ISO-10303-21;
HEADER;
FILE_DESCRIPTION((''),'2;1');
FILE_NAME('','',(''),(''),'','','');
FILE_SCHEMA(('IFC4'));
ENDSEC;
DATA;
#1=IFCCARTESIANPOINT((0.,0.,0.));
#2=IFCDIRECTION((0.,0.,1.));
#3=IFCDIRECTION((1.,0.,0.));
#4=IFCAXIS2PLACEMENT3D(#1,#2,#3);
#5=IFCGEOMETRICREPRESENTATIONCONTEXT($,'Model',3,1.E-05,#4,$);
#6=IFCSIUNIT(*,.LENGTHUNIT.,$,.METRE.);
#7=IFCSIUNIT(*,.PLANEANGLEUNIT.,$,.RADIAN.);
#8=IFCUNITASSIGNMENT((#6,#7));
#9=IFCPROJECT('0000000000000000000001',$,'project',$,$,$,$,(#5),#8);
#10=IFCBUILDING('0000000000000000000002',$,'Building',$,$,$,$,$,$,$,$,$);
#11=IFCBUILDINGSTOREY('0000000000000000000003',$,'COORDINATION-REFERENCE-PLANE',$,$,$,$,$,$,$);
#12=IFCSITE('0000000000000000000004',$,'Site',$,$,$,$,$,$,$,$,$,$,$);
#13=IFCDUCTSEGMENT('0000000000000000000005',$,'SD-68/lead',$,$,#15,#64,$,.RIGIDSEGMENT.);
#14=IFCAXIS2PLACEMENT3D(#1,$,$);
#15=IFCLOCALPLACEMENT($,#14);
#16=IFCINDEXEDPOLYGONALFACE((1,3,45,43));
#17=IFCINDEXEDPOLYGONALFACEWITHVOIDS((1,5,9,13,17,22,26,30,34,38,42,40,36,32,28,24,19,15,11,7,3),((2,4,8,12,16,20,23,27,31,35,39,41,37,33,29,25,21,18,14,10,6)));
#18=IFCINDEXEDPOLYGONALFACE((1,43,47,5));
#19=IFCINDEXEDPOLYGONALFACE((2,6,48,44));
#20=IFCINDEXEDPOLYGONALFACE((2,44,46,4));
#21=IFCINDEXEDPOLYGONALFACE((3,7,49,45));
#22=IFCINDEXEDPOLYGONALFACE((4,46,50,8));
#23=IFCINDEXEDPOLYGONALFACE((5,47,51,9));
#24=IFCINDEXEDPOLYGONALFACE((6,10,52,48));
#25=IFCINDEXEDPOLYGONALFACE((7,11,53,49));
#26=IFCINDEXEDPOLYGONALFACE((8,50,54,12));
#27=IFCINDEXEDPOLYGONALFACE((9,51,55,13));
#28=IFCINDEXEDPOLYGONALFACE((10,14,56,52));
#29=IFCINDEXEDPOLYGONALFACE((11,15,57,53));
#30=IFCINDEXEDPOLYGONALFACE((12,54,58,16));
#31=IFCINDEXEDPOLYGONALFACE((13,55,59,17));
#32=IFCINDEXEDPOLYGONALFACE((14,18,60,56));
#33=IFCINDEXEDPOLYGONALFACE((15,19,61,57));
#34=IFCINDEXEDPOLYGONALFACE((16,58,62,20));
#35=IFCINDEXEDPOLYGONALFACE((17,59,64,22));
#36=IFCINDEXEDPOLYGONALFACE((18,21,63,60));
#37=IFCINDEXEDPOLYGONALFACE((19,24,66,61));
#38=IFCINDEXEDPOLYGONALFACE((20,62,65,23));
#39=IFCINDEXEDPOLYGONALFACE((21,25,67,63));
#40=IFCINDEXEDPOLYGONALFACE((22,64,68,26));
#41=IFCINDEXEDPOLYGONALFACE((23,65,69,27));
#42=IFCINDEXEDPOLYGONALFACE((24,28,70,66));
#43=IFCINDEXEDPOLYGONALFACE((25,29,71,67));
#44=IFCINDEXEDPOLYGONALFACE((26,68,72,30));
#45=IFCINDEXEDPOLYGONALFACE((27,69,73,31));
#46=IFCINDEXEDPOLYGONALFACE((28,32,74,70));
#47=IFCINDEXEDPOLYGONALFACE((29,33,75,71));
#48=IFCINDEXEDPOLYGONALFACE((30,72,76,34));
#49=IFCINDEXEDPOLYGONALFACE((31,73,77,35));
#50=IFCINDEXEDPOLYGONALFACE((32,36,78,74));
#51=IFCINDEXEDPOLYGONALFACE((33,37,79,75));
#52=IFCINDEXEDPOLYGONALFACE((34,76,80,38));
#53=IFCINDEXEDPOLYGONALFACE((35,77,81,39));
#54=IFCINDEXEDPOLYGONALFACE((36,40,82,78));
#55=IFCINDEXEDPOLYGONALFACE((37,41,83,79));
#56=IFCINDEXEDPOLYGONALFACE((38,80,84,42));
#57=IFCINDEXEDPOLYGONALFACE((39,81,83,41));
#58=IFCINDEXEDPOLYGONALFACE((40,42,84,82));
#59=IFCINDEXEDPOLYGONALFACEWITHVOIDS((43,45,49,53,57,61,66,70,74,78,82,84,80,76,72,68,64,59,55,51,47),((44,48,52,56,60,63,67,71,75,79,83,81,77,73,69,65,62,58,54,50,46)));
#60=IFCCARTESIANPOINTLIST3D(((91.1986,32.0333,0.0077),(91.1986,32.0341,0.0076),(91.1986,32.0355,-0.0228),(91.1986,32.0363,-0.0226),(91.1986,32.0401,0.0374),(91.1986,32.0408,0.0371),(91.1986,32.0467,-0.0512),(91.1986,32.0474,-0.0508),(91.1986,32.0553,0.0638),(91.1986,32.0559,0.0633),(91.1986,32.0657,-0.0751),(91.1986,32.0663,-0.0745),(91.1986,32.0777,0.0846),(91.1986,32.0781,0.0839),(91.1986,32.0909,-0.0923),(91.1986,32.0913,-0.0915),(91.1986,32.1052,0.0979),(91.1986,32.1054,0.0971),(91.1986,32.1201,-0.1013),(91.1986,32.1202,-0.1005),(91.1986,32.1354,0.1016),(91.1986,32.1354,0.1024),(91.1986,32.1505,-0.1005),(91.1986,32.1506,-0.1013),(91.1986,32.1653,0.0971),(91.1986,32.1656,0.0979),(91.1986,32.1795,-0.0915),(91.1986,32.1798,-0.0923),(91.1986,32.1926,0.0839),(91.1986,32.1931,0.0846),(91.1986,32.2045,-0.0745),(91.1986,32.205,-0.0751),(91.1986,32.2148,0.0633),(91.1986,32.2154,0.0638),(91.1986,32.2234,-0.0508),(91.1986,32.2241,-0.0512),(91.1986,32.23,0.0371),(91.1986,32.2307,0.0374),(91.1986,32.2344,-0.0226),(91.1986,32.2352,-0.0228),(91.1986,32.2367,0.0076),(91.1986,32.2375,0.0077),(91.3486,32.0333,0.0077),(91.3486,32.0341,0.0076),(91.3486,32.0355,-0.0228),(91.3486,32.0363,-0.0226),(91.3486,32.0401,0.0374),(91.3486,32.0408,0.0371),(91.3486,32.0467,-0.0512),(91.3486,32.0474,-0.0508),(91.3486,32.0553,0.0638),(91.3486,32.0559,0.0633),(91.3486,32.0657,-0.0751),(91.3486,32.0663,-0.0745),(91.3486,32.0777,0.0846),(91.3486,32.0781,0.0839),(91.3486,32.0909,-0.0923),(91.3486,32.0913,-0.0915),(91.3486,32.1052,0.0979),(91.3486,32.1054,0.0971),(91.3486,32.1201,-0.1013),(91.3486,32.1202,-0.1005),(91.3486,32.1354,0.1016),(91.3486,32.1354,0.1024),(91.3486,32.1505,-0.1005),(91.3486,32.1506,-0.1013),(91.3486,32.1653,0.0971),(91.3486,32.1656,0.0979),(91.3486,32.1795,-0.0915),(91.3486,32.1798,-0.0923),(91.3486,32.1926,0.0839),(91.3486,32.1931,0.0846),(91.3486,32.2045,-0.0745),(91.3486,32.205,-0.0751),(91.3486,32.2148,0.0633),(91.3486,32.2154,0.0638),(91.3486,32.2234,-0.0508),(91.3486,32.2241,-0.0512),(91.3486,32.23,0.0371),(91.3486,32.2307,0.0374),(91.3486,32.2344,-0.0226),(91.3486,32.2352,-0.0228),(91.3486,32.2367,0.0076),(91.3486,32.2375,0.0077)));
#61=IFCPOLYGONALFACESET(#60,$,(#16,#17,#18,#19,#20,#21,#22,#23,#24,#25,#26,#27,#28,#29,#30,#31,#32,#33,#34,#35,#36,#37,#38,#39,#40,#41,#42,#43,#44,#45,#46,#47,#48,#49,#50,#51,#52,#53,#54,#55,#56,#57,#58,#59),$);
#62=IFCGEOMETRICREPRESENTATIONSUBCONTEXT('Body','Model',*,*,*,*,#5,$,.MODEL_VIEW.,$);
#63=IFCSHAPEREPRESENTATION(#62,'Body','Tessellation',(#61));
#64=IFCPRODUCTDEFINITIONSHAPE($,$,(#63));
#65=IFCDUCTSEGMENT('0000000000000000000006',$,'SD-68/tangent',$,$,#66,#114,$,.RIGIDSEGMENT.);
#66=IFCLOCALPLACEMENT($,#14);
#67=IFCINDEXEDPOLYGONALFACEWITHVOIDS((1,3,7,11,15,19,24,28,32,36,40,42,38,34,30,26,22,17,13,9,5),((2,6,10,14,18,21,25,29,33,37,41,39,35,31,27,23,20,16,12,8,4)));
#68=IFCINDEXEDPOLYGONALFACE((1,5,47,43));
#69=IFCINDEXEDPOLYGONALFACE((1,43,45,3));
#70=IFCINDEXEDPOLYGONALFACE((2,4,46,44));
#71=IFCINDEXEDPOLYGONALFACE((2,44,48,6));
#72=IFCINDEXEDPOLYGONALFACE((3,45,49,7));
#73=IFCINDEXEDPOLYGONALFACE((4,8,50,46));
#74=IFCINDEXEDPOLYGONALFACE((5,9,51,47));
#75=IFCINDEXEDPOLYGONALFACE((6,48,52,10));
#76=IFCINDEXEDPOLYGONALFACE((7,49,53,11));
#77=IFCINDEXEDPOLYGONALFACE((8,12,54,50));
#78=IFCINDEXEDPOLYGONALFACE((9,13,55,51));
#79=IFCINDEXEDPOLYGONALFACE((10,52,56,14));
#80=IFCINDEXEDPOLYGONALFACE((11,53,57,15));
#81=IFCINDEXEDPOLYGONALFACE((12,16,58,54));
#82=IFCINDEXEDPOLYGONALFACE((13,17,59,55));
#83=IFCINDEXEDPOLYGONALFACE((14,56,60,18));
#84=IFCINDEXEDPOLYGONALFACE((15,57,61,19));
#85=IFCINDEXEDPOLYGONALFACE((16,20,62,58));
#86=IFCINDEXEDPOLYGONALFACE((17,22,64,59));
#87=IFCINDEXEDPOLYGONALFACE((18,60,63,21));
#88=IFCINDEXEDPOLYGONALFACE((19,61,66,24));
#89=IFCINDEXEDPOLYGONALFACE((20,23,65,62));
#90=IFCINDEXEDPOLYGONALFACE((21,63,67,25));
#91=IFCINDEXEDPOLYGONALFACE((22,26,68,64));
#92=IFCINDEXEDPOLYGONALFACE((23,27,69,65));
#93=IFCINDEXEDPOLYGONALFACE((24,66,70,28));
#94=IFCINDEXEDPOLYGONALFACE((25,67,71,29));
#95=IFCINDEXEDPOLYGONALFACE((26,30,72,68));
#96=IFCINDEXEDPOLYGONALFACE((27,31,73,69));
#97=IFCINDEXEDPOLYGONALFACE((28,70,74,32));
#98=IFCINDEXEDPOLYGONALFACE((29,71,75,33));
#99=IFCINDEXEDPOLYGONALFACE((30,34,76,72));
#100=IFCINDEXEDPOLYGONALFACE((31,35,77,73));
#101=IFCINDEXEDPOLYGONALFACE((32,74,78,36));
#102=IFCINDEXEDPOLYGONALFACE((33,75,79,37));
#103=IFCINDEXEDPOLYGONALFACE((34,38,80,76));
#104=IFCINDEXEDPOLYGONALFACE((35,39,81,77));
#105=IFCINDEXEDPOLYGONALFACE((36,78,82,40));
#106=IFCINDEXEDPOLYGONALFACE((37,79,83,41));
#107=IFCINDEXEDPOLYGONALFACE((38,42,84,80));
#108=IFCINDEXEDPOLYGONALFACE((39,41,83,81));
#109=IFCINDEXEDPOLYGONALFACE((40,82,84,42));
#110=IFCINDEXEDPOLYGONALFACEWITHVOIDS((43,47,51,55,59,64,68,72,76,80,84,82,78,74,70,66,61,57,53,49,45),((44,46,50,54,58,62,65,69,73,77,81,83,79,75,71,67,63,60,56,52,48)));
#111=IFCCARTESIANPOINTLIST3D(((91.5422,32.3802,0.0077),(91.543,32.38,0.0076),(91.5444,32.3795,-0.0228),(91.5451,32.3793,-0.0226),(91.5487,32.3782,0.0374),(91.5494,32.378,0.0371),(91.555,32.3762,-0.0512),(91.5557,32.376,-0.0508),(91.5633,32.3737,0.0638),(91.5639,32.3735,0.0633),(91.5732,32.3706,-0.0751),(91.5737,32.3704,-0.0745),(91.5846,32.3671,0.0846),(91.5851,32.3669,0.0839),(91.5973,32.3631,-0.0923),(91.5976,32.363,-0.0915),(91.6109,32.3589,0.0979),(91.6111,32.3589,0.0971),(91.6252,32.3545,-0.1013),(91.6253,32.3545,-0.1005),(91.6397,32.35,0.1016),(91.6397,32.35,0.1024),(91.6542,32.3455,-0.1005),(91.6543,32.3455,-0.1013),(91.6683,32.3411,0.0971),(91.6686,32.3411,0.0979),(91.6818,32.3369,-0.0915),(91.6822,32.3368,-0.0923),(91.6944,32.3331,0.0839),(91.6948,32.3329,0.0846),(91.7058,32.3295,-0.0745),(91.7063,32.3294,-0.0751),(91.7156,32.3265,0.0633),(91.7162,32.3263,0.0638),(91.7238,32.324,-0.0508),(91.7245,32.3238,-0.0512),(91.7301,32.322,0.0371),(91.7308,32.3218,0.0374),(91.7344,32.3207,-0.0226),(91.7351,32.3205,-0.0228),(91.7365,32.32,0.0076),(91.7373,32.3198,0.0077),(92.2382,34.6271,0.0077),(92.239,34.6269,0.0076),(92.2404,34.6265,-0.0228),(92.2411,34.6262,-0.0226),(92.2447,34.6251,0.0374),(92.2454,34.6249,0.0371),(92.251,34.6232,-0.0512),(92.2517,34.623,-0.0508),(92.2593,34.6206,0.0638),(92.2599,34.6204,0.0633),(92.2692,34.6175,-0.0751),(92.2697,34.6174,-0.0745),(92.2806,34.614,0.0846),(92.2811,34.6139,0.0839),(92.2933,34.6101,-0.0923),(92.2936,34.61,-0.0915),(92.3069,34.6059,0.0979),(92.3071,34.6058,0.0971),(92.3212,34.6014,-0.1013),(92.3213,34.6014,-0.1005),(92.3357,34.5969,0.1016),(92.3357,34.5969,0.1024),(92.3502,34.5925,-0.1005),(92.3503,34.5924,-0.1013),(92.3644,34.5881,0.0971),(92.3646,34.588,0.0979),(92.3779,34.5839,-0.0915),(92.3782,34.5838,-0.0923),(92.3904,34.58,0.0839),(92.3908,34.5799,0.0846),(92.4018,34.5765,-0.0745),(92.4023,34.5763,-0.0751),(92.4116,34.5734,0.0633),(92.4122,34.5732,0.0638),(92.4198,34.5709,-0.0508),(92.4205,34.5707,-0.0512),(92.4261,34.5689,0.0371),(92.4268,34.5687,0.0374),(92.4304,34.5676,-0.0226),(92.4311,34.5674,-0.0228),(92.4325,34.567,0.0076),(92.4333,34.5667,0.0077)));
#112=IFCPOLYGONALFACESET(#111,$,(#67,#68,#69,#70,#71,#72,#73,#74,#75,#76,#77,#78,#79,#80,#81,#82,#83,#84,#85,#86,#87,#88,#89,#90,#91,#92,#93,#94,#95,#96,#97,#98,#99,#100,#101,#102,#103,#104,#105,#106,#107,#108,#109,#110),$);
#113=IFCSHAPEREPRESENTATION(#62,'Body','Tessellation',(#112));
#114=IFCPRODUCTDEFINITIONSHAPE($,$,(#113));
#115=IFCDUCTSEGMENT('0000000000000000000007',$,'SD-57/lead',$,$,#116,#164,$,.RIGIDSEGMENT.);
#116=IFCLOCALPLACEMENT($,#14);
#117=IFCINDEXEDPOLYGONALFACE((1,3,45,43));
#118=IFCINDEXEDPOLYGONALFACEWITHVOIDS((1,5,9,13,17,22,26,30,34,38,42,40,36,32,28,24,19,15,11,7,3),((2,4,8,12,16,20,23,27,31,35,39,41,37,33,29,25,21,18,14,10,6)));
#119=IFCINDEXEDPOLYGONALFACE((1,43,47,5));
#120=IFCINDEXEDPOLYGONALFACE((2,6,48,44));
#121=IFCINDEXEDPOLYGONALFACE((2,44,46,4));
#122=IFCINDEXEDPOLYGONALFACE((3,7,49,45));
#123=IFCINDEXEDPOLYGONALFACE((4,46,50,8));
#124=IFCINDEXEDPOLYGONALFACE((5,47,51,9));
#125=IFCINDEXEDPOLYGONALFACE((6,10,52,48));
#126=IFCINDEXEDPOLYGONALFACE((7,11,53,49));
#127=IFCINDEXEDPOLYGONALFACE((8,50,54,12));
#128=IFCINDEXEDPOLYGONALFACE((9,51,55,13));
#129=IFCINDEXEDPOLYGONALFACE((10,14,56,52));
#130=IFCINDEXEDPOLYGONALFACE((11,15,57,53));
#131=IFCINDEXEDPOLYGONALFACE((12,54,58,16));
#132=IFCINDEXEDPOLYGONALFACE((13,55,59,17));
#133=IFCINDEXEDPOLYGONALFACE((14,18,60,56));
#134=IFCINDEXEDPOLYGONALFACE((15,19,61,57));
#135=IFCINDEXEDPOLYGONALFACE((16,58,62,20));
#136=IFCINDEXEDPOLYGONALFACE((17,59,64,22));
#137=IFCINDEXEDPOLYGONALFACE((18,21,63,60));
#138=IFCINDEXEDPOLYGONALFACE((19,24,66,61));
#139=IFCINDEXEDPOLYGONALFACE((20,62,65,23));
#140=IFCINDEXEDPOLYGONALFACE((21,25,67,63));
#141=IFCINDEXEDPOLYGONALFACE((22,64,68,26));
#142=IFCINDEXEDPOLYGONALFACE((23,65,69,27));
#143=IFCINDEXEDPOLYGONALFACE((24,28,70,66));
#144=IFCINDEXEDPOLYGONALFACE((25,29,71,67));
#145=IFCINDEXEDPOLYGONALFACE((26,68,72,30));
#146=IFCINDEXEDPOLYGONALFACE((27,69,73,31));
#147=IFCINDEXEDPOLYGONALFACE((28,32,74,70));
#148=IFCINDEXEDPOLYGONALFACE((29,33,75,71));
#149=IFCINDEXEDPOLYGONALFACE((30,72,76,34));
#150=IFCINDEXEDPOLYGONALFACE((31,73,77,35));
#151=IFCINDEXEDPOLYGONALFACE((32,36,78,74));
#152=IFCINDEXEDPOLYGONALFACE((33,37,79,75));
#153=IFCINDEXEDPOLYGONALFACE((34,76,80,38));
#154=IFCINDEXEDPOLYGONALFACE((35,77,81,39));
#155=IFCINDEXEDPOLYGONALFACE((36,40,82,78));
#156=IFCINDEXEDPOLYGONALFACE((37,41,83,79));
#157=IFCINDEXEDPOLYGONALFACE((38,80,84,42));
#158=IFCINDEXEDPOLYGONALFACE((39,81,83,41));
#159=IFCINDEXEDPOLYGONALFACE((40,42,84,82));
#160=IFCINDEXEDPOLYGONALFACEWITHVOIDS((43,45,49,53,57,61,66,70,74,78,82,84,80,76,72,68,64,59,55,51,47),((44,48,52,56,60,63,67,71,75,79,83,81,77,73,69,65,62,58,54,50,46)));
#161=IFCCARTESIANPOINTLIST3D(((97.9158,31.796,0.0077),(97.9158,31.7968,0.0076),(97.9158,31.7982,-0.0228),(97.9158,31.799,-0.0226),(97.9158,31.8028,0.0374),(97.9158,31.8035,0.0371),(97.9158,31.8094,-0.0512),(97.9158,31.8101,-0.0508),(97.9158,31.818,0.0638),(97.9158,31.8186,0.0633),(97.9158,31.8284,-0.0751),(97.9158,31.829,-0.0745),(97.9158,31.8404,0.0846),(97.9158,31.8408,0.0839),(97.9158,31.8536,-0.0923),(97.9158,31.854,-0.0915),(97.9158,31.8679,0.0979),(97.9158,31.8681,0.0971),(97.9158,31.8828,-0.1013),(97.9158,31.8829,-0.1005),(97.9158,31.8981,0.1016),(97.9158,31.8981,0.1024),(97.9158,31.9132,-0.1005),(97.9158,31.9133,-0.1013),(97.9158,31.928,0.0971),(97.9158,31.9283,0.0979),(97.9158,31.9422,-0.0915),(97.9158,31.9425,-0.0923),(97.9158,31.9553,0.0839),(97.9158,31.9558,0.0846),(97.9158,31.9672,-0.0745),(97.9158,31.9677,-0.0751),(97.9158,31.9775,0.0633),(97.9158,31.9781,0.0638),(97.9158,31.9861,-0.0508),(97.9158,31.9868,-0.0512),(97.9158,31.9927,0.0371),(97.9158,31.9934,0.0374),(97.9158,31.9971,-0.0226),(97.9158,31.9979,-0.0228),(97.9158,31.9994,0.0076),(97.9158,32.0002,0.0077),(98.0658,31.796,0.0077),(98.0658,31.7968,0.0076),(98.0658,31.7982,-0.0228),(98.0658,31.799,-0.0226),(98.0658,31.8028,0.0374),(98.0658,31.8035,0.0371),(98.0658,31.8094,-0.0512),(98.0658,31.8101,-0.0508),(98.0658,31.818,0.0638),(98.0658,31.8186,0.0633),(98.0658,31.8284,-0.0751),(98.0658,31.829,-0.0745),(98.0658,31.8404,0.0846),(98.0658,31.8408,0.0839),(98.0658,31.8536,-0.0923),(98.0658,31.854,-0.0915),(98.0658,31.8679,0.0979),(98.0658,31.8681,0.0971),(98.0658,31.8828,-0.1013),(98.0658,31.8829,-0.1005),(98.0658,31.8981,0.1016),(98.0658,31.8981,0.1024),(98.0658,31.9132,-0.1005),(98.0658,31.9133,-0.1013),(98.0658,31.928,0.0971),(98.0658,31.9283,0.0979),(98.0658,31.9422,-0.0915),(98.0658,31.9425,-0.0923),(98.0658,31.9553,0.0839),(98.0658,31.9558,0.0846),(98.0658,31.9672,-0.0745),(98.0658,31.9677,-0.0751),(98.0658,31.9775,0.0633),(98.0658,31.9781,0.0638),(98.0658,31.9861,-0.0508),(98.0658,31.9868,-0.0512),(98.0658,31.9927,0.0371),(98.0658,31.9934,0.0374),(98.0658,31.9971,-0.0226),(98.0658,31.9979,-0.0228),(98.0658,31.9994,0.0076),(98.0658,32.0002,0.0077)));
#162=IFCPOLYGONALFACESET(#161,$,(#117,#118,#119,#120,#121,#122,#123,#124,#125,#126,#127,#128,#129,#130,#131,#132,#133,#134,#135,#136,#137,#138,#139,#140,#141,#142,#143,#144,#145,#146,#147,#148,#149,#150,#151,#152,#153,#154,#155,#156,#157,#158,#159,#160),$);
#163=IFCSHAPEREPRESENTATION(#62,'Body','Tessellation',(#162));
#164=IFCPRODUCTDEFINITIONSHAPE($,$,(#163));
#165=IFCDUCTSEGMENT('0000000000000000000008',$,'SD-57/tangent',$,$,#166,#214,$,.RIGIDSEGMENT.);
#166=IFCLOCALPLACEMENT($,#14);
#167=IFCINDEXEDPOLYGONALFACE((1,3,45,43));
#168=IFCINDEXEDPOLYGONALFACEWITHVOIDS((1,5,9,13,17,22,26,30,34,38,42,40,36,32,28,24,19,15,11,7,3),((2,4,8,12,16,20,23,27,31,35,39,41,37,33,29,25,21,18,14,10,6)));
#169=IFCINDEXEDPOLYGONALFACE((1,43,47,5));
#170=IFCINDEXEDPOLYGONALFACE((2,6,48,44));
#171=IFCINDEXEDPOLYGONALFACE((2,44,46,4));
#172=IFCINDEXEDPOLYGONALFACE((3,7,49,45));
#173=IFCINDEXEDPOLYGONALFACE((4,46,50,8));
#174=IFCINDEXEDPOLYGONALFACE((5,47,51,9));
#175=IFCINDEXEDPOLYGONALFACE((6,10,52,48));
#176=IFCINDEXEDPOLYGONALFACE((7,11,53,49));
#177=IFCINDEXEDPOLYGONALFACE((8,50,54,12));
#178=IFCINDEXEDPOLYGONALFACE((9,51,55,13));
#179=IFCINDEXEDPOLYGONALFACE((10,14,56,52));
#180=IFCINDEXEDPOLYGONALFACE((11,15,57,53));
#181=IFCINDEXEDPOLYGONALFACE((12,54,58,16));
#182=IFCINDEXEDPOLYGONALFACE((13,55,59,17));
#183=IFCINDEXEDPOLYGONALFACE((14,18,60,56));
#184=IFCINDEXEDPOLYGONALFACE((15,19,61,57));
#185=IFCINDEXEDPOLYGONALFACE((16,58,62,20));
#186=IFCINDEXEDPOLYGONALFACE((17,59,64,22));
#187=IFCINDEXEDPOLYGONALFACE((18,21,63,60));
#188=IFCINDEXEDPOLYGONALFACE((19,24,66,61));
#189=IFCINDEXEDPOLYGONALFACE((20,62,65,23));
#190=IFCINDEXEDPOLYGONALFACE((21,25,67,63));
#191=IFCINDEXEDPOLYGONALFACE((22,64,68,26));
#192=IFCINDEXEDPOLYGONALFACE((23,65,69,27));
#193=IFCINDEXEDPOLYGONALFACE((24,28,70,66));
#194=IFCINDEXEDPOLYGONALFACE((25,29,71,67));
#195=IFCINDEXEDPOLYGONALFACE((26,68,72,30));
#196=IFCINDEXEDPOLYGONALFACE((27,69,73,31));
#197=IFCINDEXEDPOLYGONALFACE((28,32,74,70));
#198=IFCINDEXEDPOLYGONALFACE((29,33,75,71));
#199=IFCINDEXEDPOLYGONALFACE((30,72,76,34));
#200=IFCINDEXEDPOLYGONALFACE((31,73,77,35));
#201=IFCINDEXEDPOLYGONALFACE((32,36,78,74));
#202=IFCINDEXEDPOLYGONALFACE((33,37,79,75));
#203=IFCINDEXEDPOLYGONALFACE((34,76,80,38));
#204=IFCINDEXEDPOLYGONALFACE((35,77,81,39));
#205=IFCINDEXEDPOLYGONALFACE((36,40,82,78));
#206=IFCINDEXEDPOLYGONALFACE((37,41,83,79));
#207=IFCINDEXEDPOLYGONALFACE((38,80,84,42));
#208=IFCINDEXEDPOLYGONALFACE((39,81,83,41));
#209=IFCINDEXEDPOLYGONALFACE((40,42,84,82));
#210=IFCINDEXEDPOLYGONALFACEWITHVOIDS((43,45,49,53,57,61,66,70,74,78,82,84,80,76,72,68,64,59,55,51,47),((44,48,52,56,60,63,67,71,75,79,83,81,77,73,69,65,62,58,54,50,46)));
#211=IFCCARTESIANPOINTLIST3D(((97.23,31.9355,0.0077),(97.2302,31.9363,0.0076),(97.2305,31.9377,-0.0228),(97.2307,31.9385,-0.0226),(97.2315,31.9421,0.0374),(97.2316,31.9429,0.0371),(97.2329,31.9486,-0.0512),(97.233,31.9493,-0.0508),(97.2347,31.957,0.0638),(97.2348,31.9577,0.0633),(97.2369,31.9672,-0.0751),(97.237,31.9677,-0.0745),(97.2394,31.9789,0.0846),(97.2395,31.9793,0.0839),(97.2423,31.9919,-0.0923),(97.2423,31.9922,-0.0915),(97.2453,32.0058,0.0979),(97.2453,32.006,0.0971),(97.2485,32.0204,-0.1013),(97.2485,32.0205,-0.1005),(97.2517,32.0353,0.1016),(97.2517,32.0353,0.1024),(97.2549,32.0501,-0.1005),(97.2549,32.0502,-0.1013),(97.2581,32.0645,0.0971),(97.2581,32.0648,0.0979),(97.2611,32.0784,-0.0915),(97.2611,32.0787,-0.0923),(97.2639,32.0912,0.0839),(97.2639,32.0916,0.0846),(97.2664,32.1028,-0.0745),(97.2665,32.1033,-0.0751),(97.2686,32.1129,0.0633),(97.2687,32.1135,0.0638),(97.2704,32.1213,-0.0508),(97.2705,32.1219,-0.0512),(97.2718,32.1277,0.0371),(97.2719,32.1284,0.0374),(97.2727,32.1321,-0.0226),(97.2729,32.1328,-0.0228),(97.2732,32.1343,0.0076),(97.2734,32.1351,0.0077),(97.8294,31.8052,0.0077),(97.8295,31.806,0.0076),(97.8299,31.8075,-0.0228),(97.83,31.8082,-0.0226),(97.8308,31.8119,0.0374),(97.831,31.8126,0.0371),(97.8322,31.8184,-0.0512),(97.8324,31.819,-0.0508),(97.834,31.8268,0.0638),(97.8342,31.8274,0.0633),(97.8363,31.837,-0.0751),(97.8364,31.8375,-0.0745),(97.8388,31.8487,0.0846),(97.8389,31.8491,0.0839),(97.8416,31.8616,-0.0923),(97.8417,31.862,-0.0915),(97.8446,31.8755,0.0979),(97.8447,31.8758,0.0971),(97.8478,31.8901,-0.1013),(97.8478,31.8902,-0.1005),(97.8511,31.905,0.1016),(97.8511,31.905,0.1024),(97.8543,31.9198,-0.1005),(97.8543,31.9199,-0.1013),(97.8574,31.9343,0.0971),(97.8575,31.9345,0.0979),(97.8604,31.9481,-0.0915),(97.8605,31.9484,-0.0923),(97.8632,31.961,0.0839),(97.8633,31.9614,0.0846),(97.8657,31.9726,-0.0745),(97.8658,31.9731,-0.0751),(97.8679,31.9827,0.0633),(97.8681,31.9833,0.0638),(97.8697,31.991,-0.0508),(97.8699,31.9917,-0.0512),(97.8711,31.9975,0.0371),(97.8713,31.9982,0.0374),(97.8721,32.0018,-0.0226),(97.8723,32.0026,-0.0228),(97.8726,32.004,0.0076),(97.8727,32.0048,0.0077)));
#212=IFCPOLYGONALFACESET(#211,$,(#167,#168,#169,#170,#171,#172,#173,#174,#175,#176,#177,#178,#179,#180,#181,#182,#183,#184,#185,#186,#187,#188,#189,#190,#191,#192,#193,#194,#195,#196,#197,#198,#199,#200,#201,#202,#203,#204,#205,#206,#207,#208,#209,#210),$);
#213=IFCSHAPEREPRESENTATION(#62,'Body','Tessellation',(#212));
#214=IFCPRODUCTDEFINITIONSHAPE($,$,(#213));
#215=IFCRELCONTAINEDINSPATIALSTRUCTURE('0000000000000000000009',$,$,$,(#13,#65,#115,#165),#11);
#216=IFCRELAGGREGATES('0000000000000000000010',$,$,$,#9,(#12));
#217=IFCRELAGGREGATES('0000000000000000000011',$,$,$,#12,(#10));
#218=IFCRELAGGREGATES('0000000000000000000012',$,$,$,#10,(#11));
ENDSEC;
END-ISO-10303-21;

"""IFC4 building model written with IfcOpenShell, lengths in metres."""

from ifc_helpers import new_model, si_unit, frame, origin_with_axes, place, context, subcontext, project, spatial, hollow_circle, extrude, element, save


model = new_model("IFC4")

# Units and contexts
model_context = context("Model", 3, precision=1e-05, world=origin_with_axes())
body_context_1 = subcontext(model_context, "Body", "Model", "MODEL_VIEW")
ifc_project = project(units=[si_unit("LENGTHUNIT", "METRE"), si_unit("PLANEANGLEUNIT", "RADIAN")], contexts=[model_context])

# Site, building, storey
site = spatial("IfcSite", under=ifc_project, Name="Site")
building = spatial("IfcBuilding", under=site, Name="Building")
storey = spatial("IfcBuildingStorey", under=building, Name="COORDINATION-REFERENCE-PLANE")

# Duct segments
for number, where, z_axis, x_axis, name in (
    (1, (91.1986, 32.1354, 0.0), (1.0, 0.0, 0.0), (0.0, 0.0, 1.0), "SD-68/lead"),
):
    element("IfcDuctSegment", number, at=place(None, frame(where, z_axis=z_axis, x_axis=x_axis)), inside=storey, Name=name, PredefinedType="RIGIDSEGMENT", context=body_context_1, shape_type="SweptSolid", body=[
        extrude(hollow_circle(Radius=0.1024, WallThickness=0.0008), origin_with_axes(), (0.0, 0.0, 1.0), 0.15),
    ])
duct_segment_1_placement = place(None, frame((91.6397, 32.35, 0.0), z_axis=(0.295887, 0.955223, 0.0), x_axis=(0.0, 0.0, 1.0)))
element("IfcDuctSegment", 2, at=duct_segment_1_placement, inside=storey, Name="SD-68/tangent", PredefinedType="RIGIDSEGMENT", context=body_context_1, shape_type="SweptSolid", body=[
    extrude(hollow_circle(Radius=0.1024, WallThickness=0.0008), origin_with_axes(), (0.0, 0.0, 1.0), 2.3523),
])
duct_segment_2_placement = place(None, frame((98.0658, 31.8981, 0.0), z_axis=(-1.0, 0.0, 0.0), x_axis=(0.0, 0.0, 1.0)))
element("IfcDuctSegment", 3, at=duct_segment_2_placement, inside=storey, Name="SD-57/lead", PredefinedType="RIGIDSEGMENT", context=body_context_1, shape_type="SweptSolid", body=[
    extrude(hollow_circle(Radius=0.1024, WallThickness=0.0008), origin_with_axes(), (0.0, 0.0, 1.0), 0.15),
])

# Duct segment
duct_segment_3_placement = place(None, frame((97.8511, 31.905, 0.0), z_axis=(-0.977193, 0.212353, 0.0), x_axis=(0.0, 0.0, 1.0)))
element("IfcDuctSegment", 4, at=duct_segment_3_placement, inside=storey, Name="SD-57/tangent", PredefinedType="RIGIDSEGMENT", context=body_context_1, shape_type="SweptSolid", body=[
    extrude(hollow_circle(Radius=0.1024, WallThickness=0.0008), origin_with_axes(), (0.0, 0.0, 1.0), 0.6133),
])

save(model, "model.ifc")
